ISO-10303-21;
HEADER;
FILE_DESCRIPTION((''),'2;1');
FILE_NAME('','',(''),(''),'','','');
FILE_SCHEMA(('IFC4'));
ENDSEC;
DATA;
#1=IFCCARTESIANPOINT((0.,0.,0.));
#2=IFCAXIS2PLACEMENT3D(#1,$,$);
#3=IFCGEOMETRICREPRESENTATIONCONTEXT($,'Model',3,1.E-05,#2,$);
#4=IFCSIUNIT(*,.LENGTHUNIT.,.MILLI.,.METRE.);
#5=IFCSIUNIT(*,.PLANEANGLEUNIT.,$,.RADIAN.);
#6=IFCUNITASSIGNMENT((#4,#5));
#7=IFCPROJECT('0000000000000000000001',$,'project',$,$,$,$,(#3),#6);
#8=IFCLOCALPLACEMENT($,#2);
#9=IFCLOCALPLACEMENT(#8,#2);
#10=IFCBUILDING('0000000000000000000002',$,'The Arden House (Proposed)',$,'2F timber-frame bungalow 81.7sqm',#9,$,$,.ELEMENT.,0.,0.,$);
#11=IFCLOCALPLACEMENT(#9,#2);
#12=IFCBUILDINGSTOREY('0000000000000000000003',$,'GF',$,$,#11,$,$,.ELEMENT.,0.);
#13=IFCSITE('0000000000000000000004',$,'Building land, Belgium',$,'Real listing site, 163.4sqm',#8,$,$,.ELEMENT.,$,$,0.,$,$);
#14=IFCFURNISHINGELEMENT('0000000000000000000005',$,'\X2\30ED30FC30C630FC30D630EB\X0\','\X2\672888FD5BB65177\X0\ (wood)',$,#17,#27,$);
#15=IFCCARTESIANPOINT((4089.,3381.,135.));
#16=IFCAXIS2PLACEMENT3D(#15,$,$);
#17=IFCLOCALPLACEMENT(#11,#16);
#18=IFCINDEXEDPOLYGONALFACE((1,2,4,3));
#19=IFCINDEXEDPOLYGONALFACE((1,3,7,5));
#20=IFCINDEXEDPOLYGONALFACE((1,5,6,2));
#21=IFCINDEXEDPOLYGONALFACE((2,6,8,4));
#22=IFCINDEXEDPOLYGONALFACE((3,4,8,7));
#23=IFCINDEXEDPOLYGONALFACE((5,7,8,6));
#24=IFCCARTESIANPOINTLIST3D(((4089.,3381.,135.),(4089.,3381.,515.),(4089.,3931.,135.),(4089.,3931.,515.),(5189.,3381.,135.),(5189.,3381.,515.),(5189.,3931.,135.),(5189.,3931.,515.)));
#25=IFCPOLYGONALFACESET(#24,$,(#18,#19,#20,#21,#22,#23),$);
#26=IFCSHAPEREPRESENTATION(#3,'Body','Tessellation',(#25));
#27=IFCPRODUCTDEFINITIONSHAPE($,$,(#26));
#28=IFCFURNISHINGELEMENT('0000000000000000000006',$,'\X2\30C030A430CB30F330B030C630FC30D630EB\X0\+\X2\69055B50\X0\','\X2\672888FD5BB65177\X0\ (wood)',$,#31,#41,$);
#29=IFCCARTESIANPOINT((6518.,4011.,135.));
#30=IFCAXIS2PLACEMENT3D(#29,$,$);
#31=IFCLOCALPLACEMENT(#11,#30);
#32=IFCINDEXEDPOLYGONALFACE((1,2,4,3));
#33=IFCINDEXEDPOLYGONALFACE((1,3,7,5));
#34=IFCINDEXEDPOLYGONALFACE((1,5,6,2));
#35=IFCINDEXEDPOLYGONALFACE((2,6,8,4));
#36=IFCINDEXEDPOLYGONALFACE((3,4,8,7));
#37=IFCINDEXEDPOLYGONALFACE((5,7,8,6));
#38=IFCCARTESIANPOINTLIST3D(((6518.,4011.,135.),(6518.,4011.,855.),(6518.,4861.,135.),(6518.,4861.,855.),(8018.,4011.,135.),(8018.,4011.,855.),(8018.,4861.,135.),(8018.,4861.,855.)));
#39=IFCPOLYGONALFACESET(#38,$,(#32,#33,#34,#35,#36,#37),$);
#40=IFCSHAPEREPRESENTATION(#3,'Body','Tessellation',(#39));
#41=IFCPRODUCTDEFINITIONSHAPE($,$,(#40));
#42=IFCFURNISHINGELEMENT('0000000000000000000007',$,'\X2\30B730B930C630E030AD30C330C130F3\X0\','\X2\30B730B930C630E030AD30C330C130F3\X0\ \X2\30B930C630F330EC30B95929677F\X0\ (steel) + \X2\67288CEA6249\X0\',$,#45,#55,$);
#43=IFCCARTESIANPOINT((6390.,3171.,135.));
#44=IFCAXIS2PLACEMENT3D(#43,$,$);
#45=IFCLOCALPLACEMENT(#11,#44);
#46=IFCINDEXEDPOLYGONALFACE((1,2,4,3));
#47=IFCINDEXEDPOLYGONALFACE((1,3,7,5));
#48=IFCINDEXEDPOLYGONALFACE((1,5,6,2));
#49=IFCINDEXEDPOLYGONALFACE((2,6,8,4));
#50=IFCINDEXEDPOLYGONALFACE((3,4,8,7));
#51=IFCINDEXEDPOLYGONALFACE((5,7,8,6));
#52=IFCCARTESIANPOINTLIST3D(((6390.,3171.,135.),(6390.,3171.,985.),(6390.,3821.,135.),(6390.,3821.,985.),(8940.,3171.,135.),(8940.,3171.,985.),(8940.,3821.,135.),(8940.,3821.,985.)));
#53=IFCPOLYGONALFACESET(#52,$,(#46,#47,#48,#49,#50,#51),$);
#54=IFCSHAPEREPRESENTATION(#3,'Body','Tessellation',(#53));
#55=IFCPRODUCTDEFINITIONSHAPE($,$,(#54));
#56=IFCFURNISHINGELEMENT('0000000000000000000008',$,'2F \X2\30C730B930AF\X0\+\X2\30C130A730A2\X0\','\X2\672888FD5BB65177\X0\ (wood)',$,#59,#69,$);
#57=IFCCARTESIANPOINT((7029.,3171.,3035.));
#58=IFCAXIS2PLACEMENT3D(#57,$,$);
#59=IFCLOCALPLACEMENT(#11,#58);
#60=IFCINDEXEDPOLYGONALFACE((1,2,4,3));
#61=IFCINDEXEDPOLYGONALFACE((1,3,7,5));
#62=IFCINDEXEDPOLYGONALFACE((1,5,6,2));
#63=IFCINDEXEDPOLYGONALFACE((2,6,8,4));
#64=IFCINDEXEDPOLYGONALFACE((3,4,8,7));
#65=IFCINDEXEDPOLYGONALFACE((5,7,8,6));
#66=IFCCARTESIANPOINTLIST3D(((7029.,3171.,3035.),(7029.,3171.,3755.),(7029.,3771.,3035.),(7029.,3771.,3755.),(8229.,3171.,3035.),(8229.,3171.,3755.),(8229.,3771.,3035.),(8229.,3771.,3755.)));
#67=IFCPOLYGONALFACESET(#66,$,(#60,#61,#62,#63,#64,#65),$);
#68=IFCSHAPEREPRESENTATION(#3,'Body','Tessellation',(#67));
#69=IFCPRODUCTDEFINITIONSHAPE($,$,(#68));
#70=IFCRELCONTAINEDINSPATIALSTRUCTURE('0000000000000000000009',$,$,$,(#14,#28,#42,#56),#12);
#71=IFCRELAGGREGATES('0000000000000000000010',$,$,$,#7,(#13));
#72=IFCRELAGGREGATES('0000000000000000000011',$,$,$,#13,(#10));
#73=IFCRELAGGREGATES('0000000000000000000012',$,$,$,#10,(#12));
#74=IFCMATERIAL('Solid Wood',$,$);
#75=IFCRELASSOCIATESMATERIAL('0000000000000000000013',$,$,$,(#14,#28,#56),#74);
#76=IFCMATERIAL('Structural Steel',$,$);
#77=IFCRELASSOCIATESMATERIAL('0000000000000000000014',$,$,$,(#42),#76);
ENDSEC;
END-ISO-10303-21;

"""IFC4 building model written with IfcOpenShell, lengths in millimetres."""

from ifc_helpers import new_model, si_unit, frame, frame_2d, origin, place, context, project, spatial, rectangle, extrude, material, element, save


model = new_model("IFC4")

# Units and contexts
model_context = context("Model", 3, precision=1e-05, world=origin())
ifc_project = project(units=[si_unit("LENGTHUNIT", "METRE", prefix="MILLI"), si_unit("PLANEANGLEUNIT", "RADIAN")], contexts=[model_context])

# Site, building, storey
site_placement = place(None, origin())
site = spatial("IfcSite", under=ifc_project, at=site_placement, Name="Building land, Belgium", ObjectType="Real listing site, 163.4sqm", CompositionType="ELEMENT", RefElevation=0.0)
building_placement = place(site_placement, origin())
building = spatial("IfcBuilding", under=site, at=building_placement, Name="The Arden House (Proposed)", ObjectType="2F timber-frame bungalow 81.7sqm", CompositionType="ELEMENT", ElevationOfRefHeight=0.0, ElevationOfTerrain=0.0)
storey_placement = place(building_placement, origin())
storey = spatial("IfcBuildingStorey", under=building, at=storey_placement, Name="GF", CompositionType="ELEMENT", Elevation=0.0)

# Shared definitions
ifc_material_1 = material(Name="Solid Wood")

# Shared definitions
ifc_material_2 = material(Name="Structural Steel")

# Furnishing elements
furnishing_1_placement = place(storey_placement, frame((4089.0, 3381.0, 135.0)))
element("IfcFurnishingElement", 1, at=furnishing_1_placement, inside=storey, material=ifc_material_1, Name="ローテーブル", Description="木製家具 (wood)", context=model_context, shape_type="SweptSolid", body=[
    extrude(rectangle(XDim=1100.0, YDim=550.0, at=frame_2d((550.0, 275.0))), frame((4089.0, 3381.0, 135.0)), (0.0, 0.0, 1.0), 380.0),
])
furnishing_2_placement = place(storey_placement, frame((6518.0, 4011.0, 135.0)))
element("IfcFurnishingElement", 2, at=furnishing_2_placement, inside=storey, material=ifc_material_1, Name="ダイニングテーブル+椅子", Description="木製家具 (wood)", context=model_context, shape_type="SweptSolid", body=[
    extrude(rectangle(XDim=1500.0, YDim=850.0, at=frame_2d((750.0, 425.0))), frame((6518.0, 4011.0, 135.0)), (0.0, 0.0, 1.0), 720.0),
])
furnishing_3_placement = place(storey_placement, frame((6390.0, 3171.0, 135.0)))
element("IfcFurnishingElement", 3, at=furnishing_3_placement, inside=storey, material=ifc_material_2, Name="システムキッチン", Description="システムキッチン ステンレス天板 (steel) + 木質扉", context=model_context, shape_type="SweptSolid", body=[
    extrude(rectangle(XDim=2550.0, YDim=650.0, at=frame_2d((1275.0, 325.0))), frame((6390.0, 3171.0, 135.0)), (0.0, 0.0, 1.0), 850.0),
])
furnishing_4_placement = place(storey_placement, frame((7029.0, 3171.0, 3035.0)))
element("IfcFurnishingElement", 4, at=furnishing_4_placement, inside=storey, material=ifc_material_1, Name="2F デスク+チェア", Description="木製家具 (wood)", context=model_context, shape_type="SweptSolid", body=[
    extrude(rectangle(XDim=1200.0, YDim=600.0, at=frame_2d((600.0, 300.0))), frame((7029.0, 3171.0, 3035.0)), (0.0, 0.0, 1.0), 720.0),
])

save(model, "model.ifc")
